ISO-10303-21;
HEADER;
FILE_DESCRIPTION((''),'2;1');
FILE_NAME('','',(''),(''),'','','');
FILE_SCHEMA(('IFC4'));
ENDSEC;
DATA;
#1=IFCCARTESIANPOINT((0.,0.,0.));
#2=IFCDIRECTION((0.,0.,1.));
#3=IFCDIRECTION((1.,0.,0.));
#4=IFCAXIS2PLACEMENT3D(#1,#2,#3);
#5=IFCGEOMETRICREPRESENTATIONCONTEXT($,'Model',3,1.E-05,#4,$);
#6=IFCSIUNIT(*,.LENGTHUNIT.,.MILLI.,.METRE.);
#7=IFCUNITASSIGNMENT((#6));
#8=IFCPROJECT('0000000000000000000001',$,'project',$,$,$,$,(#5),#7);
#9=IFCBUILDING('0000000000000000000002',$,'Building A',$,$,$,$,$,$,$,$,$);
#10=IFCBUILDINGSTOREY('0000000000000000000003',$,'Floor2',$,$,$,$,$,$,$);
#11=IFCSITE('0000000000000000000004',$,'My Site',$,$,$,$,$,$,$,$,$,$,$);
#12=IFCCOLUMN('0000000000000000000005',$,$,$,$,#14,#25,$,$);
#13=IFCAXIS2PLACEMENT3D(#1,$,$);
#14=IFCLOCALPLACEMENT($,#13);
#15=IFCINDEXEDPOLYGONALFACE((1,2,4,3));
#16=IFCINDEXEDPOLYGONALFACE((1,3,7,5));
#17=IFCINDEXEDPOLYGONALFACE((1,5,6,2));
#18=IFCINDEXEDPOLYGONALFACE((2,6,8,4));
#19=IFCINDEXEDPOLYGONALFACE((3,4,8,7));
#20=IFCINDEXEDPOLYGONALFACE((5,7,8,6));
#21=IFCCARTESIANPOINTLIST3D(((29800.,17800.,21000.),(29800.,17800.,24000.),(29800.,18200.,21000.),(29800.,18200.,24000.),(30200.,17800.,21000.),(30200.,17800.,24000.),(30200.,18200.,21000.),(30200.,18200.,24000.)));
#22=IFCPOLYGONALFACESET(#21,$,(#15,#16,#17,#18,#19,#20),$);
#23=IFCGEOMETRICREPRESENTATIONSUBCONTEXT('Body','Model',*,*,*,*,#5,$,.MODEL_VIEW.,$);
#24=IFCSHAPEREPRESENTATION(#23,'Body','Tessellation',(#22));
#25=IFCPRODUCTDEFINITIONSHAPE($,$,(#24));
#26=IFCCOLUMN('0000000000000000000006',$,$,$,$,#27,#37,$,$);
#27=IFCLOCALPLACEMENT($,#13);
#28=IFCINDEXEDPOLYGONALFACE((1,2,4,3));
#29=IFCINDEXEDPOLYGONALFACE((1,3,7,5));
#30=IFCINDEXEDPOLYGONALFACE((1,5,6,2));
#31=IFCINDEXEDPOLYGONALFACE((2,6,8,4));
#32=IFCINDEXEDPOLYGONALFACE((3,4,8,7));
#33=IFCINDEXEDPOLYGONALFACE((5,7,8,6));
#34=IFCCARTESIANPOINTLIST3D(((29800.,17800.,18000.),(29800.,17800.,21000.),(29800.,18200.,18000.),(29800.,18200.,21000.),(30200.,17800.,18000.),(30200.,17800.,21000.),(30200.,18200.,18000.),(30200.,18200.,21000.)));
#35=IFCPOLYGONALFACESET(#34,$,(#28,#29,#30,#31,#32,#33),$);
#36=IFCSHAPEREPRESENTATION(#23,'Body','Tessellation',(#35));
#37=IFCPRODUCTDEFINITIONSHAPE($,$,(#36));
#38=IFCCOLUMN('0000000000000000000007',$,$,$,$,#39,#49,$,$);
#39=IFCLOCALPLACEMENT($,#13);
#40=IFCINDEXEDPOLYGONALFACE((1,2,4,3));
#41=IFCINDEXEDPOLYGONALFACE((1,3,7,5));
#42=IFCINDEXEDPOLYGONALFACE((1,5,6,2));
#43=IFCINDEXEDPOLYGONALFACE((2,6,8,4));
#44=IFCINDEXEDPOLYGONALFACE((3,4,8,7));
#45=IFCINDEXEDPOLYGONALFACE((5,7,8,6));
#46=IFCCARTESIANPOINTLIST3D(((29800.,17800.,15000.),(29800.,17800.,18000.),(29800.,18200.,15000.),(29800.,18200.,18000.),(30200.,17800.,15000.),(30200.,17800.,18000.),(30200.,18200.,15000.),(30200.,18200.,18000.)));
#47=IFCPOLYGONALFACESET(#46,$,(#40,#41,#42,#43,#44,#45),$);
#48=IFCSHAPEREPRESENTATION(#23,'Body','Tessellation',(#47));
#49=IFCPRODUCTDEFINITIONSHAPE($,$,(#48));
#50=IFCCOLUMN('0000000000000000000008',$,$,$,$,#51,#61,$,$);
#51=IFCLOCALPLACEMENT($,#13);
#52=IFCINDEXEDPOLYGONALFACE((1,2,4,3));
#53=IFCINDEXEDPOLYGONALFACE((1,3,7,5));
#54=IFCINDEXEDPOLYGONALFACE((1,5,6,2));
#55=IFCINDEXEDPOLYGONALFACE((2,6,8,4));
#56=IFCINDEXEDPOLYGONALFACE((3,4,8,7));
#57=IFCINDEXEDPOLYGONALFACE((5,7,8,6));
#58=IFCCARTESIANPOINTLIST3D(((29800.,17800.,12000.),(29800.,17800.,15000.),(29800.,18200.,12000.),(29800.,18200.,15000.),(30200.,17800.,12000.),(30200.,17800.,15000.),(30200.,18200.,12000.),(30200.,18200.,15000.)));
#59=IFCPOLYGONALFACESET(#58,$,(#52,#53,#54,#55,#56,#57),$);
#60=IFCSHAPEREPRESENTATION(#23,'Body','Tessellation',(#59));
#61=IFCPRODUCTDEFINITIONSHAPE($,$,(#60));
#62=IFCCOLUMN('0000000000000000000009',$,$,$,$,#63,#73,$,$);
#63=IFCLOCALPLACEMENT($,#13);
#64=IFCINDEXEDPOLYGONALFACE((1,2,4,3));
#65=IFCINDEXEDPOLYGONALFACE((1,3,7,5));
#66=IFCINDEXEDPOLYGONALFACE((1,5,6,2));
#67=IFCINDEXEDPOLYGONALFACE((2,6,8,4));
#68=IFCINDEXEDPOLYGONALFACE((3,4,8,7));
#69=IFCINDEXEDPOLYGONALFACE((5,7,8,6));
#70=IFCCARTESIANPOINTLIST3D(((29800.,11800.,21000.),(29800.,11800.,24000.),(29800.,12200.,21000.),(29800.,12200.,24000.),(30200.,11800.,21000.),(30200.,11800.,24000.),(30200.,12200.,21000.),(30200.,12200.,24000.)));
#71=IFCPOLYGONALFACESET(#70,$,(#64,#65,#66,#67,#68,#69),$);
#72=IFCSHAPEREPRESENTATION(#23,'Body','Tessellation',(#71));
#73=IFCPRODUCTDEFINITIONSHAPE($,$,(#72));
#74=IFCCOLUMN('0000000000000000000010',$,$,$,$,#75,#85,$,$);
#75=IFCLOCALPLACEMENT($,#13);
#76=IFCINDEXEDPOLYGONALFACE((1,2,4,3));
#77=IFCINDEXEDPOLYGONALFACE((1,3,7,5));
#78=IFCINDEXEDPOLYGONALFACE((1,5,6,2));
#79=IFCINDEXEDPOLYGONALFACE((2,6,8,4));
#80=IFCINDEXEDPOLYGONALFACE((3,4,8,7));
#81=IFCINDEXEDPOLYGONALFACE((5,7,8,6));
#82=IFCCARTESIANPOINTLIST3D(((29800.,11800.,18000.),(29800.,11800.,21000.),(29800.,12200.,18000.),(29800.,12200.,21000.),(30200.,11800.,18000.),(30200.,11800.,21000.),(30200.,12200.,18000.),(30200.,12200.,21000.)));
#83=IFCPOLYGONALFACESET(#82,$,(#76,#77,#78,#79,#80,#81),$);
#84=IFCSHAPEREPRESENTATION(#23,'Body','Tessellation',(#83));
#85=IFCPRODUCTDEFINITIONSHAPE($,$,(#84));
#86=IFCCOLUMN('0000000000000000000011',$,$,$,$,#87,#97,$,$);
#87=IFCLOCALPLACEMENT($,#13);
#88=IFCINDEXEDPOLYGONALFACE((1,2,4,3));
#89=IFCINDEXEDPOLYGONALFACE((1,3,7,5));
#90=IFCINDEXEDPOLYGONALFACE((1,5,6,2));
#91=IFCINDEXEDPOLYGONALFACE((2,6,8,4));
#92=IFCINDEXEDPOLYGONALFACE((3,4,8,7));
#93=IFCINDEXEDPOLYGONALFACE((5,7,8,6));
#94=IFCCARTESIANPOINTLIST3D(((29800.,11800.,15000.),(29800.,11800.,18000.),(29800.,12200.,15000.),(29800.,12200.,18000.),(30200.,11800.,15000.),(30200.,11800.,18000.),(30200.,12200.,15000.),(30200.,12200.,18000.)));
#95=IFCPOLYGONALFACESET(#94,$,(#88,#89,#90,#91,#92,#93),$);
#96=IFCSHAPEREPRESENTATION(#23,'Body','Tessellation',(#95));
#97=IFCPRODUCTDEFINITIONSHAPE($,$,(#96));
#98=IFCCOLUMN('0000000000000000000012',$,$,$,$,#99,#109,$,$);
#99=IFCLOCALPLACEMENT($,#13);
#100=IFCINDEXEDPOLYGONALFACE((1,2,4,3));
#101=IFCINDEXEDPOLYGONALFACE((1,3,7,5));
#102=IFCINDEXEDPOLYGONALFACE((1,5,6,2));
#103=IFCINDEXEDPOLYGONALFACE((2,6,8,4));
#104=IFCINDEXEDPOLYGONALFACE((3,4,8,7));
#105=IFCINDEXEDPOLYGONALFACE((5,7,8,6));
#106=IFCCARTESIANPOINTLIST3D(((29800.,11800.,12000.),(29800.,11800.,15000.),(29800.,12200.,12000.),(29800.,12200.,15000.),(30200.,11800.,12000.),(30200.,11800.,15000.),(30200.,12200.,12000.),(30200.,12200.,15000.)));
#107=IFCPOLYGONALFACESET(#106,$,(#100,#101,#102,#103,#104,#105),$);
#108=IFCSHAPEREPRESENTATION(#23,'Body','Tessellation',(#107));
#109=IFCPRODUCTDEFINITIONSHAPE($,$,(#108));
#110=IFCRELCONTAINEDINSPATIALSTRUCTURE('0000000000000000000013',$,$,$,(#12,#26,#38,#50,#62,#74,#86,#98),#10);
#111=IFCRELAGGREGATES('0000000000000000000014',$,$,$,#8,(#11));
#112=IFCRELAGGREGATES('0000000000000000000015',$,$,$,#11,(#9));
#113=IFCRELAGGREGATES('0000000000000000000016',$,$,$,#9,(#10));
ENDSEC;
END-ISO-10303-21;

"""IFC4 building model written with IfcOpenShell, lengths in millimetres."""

from ifc_helpers import new_model, si_unit, frame, origin_with_axes, place, context, subcontext, project, spatial, line, indexed_curve, outline, extrude, element, save


model = new_model("IFC4")

# Units and contexts
model_context = context("Model", 3, precision=1e-05, world=origin_with_axes())
body_context = subcontext(model_context, "Body", "Model", "MODEL_VIEW")
ifc_project = project(units=[si_unit("LENGTHUNIT", "METRE", prefix="MILLI")], contexts=[model_context])

# Site, building, storey
site = spatial("IfcSite", under=ifc_project, Name="My Site")
building = spatial("IfcBuilding", under=site, Name="Building A")
storey = spatial("IfcBuildingStorey", under=building, Name="Floor2")

# Columns
for number, where, z_axis, x_axis in (
    (1, (30000.0, 18000.0, 21000.0), (0.0, 0.0, 1.0), (1.0, 0.0, 0.0)),
    (2, (30000.0, 18000.0, 18000.0), (0.0, 0.0, 1.0), (1.0, 0.0, 0.0)),
    (3, (30000.0, 18000.0, 15000.0), (0.0, 0.0, 1.0), (1.0, 0.0, 0.0)),
    (4, (30000.0, 18000.0, 12000.0), (0.0, 0.0, 1.0), (1.0, 0.0, 0.0)),
    (5, (30000.0, 12000.0, 21000.0), (0.0, 0.0, 1.0), (1.0, 0.0, 0.0)),
    (6, (30000.0, 12000.0, 18000.0), (0.0, 0.0, 1.0), (1.0, 0.0, 0.0)),
    (7, (30000.0, 12000.0, 15000.0), (0.0, 0.0, 1.0), (1.0, 0.0, 0.0)),
    (8, (30000.0, 12000.0, 12000.0), (0.0, 0.0, 1.0), (1.0, 0.0, 0.0)),
):
    element("IfcColumn", number, at=place(None, frame(where, z_axis=z_axis, x_axis=x_axis)), inside=storey, context=body_context, shape_type="SweptSolid", body=[
        extrude(outline(indexed_curve([(-200.0, -200.0), (200.0, -200.0), (200.0, 200.0), (-200.0, 200.0)], segments=[line(1, 2, 3, 4, 1)])), origin_with_axes(), (0.0, 0.0, 1.0), 3000.0),
    ])

save(model, "model.ifc")
